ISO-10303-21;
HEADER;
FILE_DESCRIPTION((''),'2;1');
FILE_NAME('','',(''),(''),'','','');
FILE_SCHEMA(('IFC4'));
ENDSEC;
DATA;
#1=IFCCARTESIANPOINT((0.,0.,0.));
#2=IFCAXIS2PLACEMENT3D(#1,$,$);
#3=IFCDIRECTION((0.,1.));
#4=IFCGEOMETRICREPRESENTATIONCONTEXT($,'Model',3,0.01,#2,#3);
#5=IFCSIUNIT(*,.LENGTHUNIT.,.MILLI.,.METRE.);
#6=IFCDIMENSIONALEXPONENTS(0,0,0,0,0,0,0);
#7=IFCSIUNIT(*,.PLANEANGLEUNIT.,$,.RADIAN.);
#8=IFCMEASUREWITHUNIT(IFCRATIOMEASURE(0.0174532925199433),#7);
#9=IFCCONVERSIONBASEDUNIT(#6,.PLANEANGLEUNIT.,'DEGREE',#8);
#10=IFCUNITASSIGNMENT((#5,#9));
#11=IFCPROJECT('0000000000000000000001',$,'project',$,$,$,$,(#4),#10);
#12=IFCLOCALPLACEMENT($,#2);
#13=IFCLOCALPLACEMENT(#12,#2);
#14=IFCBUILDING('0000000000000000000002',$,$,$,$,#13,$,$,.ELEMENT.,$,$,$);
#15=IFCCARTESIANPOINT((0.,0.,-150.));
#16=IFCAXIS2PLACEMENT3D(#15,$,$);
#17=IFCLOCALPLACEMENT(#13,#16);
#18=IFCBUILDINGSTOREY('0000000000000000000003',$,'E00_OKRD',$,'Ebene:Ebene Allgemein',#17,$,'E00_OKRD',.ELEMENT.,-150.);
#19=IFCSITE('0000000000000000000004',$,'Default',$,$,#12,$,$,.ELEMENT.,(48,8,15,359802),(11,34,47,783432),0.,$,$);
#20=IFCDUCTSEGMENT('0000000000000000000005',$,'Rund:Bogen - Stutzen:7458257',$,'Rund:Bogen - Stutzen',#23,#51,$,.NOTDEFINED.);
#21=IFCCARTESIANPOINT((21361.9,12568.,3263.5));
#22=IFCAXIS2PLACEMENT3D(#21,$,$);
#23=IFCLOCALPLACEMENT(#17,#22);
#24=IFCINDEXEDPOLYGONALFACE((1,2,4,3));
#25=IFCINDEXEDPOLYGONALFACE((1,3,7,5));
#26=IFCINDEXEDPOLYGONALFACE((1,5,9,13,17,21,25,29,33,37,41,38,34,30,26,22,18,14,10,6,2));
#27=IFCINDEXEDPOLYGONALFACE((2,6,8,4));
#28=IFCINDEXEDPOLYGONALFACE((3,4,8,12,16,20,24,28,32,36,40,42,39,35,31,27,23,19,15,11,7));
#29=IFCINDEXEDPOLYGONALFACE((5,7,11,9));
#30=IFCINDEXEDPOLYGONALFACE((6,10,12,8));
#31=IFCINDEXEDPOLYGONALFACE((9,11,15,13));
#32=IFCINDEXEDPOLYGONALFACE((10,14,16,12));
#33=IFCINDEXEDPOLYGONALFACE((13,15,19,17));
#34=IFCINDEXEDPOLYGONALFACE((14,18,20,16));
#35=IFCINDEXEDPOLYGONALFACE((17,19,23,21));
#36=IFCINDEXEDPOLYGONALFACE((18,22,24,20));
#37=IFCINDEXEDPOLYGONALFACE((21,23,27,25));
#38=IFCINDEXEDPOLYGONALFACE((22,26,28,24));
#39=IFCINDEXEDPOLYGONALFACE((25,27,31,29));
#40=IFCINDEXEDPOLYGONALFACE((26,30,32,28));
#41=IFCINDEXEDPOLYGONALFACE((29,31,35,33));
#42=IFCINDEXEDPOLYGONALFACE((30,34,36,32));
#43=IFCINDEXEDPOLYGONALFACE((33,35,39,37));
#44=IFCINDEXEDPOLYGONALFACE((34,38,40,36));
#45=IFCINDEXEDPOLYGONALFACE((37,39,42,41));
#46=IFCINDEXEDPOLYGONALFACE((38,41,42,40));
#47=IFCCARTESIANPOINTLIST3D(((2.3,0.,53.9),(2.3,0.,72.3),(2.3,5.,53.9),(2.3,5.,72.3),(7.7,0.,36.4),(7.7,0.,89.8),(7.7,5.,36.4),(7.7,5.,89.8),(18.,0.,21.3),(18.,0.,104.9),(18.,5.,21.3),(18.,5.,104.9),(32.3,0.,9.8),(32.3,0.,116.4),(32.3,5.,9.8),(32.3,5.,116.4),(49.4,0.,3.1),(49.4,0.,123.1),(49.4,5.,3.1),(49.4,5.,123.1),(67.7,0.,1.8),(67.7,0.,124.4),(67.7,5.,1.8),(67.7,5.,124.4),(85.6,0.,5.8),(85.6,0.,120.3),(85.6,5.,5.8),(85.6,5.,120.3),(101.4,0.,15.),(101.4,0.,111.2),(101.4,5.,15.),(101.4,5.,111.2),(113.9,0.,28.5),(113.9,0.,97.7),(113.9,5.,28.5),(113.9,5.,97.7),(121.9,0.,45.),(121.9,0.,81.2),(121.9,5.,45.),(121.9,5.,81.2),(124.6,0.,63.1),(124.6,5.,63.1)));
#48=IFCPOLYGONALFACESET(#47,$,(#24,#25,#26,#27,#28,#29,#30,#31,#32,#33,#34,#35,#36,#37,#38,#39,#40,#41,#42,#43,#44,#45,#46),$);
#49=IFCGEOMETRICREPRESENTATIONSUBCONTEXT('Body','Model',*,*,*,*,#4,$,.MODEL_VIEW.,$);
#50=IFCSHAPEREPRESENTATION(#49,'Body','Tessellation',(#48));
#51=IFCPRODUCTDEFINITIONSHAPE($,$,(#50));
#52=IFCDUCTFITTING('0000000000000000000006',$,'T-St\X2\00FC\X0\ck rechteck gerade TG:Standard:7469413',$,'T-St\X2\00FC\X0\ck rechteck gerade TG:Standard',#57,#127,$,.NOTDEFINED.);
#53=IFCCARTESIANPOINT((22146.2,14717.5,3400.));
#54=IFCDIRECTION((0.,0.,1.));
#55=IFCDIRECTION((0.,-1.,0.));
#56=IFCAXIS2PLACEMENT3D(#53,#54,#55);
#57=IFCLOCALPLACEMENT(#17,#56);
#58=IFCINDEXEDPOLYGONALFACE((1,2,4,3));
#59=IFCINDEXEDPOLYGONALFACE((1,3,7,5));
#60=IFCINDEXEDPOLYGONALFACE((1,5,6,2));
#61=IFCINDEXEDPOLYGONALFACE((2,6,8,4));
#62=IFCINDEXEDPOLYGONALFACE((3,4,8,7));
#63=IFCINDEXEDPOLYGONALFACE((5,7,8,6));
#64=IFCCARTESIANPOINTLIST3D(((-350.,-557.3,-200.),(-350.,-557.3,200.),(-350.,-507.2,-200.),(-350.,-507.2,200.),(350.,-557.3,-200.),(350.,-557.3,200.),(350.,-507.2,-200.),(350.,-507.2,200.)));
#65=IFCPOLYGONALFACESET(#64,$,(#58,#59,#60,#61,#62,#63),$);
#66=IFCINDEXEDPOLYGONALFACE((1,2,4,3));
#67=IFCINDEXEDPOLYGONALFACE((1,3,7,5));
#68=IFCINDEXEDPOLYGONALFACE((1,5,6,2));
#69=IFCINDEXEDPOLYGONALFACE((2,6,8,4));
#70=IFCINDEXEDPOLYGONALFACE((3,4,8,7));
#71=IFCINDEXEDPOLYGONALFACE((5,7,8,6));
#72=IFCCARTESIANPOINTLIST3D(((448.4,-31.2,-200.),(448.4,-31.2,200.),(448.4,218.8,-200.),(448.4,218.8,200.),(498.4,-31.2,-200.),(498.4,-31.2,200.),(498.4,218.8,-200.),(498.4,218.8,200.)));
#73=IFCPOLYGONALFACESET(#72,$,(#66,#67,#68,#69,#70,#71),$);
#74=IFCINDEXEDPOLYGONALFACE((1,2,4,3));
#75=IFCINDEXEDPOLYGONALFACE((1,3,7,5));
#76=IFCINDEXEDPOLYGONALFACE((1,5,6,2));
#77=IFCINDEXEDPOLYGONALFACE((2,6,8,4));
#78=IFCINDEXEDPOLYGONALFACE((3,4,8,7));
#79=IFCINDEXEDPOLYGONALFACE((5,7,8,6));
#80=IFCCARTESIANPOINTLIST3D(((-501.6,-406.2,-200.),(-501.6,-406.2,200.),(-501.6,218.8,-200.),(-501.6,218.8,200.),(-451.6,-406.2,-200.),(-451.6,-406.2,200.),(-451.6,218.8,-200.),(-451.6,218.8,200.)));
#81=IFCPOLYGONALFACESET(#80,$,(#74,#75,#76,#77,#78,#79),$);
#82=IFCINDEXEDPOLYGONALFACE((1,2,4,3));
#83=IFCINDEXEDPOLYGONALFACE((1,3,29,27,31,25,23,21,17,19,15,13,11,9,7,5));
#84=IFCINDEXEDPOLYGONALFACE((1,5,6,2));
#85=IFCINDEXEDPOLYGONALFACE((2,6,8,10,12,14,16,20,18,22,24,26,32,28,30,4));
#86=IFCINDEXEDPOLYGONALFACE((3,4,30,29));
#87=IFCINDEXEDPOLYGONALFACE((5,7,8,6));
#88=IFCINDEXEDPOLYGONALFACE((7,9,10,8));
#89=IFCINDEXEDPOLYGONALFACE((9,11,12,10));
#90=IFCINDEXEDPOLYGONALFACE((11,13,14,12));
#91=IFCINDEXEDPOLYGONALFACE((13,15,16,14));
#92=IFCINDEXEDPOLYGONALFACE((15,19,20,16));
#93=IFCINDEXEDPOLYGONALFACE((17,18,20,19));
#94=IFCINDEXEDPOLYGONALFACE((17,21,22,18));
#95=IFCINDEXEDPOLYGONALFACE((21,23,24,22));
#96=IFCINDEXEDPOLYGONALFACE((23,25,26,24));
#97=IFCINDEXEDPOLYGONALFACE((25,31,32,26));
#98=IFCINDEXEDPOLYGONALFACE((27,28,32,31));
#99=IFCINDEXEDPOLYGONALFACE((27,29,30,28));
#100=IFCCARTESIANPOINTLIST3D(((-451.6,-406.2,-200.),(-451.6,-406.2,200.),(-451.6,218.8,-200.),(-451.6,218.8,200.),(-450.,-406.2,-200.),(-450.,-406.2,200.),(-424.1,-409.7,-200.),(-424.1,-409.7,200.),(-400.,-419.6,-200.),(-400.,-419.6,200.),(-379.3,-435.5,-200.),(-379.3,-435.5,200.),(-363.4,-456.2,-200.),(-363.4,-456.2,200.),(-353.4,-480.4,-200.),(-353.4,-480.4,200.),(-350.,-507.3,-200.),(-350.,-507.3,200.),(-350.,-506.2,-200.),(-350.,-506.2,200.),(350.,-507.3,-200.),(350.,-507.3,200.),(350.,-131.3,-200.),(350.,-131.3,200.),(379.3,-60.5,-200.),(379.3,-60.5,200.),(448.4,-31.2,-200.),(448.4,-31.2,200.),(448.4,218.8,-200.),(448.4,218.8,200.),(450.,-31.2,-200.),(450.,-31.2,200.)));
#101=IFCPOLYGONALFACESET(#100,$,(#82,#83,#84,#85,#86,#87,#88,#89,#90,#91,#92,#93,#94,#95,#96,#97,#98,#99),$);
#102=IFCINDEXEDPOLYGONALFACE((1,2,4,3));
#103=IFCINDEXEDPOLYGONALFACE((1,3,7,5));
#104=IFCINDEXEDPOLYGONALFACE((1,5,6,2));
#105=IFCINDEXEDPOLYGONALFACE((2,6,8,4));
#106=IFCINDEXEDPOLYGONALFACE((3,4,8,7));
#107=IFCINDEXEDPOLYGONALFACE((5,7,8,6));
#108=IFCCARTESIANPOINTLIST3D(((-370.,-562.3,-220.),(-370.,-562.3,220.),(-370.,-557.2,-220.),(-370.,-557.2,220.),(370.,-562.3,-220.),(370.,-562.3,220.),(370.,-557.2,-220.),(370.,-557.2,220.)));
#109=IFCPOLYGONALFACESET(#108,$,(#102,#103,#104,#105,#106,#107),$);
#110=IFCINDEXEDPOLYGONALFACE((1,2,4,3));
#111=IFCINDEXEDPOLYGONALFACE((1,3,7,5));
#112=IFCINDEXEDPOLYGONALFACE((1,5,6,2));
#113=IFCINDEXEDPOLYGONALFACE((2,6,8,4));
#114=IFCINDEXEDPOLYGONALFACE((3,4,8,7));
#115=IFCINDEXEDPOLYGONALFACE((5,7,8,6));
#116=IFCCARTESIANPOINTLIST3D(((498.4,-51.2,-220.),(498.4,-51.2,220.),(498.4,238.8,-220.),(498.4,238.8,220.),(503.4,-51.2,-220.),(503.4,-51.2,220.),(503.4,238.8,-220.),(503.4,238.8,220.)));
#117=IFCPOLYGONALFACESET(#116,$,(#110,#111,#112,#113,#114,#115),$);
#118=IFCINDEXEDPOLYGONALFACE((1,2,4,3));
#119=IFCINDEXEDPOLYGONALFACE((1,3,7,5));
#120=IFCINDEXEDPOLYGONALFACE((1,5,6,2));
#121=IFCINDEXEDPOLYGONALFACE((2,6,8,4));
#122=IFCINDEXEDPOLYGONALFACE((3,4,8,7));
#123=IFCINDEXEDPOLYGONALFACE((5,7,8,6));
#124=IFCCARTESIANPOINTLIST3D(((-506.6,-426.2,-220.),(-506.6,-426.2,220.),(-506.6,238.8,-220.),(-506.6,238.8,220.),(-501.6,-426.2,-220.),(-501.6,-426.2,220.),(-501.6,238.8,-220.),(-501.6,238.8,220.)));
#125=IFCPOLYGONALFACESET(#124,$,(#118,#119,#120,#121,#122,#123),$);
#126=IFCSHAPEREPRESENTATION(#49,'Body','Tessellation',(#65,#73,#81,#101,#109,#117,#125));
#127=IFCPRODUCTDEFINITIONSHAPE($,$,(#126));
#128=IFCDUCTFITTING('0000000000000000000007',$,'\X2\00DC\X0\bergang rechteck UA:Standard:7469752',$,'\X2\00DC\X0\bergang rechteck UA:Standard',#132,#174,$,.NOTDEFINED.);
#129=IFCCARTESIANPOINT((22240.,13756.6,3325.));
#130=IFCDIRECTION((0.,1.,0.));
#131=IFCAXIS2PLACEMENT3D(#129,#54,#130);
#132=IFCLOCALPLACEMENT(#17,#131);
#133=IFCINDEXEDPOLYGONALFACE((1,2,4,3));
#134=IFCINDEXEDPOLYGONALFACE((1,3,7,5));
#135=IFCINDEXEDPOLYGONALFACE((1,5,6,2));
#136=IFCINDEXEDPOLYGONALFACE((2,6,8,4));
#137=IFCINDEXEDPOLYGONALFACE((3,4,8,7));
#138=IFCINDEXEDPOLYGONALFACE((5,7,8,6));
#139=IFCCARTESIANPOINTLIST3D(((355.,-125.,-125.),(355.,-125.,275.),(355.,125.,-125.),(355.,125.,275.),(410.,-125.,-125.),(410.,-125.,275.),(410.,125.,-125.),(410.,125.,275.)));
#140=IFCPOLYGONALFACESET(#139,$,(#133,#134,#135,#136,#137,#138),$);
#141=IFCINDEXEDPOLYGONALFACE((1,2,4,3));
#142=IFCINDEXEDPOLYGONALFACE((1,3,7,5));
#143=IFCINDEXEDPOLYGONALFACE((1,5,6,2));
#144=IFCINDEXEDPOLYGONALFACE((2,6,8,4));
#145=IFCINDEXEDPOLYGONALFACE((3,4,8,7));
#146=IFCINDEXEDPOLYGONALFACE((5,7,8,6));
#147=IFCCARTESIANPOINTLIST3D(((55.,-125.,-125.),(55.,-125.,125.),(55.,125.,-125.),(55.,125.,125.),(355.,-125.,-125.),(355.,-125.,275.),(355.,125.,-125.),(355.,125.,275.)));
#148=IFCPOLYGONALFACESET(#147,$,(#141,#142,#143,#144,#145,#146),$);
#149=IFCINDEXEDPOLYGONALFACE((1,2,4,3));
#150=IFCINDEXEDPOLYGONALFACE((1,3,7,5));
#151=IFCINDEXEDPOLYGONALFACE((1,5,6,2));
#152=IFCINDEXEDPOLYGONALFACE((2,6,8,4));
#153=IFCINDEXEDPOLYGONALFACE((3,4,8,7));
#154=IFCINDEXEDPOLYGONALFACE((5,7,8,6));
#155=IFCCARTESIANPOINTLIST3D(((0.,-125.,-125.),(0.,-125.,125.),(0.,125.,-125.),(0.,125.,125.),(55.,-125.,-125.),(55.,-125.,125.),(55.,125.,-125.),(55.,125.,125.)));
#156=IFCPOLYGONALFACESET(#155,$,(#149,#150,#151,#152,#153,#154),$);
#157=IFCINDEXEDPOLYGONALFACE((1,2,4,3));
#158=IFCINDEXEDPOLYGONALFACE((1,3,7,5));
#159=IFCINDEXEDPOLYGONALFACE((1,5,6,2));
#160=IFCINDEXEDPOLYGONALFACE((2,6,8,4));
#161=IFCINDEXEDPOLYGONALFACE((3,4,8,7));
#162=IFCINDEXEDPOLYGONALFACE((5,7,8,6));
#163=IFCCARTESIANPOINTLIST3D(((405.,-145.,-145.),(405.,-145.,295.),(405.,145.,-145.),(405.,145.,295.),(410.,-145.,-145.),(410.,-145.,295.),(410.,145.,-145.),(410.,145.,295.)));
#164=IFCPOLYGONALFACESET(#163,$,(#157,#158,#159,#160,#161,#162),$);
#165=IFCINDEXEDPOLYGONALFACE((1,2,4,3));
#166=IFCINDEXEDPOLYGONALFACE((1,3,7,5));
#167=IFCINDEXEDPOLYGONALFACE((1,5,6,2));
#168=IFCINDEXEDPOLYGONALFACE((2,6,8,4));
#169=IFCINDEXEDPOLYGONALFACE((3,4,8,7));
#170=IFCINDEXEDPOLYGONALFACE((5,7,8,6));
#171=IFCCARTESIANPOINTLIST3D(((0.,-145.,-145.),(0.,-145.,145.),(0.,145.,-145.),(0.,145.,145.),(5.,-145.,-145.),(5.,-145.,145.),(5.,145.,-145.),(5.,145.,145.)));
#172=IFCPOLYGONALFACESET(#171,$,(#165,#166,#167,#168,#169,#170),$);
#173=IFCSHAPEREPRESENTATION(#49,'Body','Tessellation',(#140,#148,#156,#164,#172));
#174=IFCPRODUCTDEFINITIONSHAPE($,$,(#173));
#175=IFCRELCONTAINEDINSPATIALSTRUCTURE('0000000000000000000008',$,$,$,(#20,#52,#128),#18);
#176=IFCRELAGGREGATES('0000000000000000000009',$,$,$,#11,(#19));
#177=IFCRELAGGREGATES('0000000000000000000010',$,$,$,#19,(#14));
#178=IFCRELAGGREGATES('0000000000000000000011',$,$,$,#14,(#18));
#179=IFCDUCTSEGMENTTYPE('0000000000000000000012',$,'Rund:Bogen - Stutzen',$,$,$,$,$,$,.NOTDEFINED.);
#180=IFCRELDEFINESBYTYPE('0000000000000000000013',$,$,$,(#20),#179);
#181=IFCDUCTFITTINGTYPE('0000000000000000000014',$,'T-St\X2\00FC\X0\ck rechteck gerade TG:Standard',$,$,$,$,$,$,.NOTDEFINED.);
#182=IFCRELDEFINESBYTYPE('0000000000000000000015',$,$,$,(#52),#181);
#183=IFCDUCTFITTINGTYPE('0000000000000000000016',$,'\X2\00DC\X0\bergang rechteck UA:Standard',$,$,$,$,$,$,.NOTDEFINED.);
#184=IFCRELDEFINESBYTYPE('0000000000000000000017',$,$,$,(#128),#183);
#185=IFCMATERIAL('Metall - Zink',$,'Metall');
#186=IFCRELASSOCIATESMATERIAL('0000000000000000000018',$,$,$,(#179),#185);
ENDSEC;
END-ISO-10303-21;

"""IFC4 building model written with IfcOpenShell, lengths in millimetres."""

from ifc_helpers import new_model, entity, si_unit, converted_unit, direction, frame, frame_2d, origin, origin_2d_with_axis, place, context, subcontext, project, spatial, polyline, circle_curve, parameter, trimmed, segment, composite_curve, rectangle, circle, outline, extrude, source, transform, mapped, material, type_object, type_shapes, element, save


model = new_model("IFC4")

# Units and contexts
model_context = context("Model", 3, precision=0.01, world=origin(), true_north=direction((0.0, 1.0)))
body_context = subcontext(model_context, "Body", "Model", "MODEL_VIEW")
ifc_project = project(units=[si_unit("LENGTHUNIT", "METRE", prefix="MILLI"), converted_unit("PLANEANGLEUNIT", "DEGREE", entity("IfcRatioMeasure", 0.0174532925199433), si_unit("PLANEANGLEUNIT", "RADIAN"), dimensions=[0, 0, 0, 0, 0, 0, 0])], contexts=[model_context])

# Site, building, storey
site_placement = place(None, origin())
site = spatial("IfcSite", under=ifc_project, at=site_placement, Name="Default", CompositionType="ELEMENT", RefLatitude=(48, 8, 15, 359802), RefLongitude=(11, 34, 47, 783432), RefElevation=0.0)
building_placement = place(site_placement, origin())
building = spatial("IfcBuilding", under=site, at=building_placement, CompositionType="ELEMENT")
storey_placement = place(building_placement, frame((0.0, 0.0, -150.0)))
storey = spatial("IfcBuildingStorey", under=building, at=storey_placement, Name="E00_OKRD", ObjectType="Ebene:Ebene Allgemein", LongName="E00_OKRD", CompositionType="ELEMENT", Elevation=-150.0)

# Duct segment
ifc_material = material(Name="Metall - Zink", Category="Metall")
duct_segment_type_1 = type_object("IfcDuctSegmentType", Name="Rund:Bogen - Stutzen", PredefinedType="NOTDEFINED", material=ifc_material)
duct_segment_1_placement = place(storey_placement, frame((21361.9, 12568.0, 3263.5)))
element("IfcDuctSegment", 1, at=duct_segment_1_placement, inside=storey, type_object=duct_segment_type_1, Name="Rund:Bogen - Stutzen:7458257", ObjectType="Rund:Bogen - Stutzen", PredefinedType="NOTDEFINED", context=body_context, shape_type="SweptSolid", body=[
    extrude(circle(Radius=61.5, at=origin_2d_with_axis()), frame((63.1, 0.0, 63.1), z_axis=(0.0, 1.0, 0.0), x_axis=(1.0, 0.0, 0.0)), (0.0, 0.0, 1.0), 5.0),
])

# Duct fittings
duct_fitting_type_1 = type_object("IfcDuctFittingType", Name="T-Stück rechteck gerade TG:Standard", PredefinedType="NOTDEFINED")
shared_shape_1 = source(origin(), body_context, "Body", "SweptSolid", [
    extrude(rectangle(XDim=50.0, YDim=700.0, at=frame_2d((0.0, 0.0), x_axis=(1.0, 0.0))), frame((0.0, -532.2, -200.0), z_axis=(0.0, 0.0, 1.0), x_axis=(0.0, -1.0, 0.0)), (0.0, 0.0, 1.0), 400.0),
    extrude(rectangle(XDim=50.0, YDim=250.0, at=frame_2d((0.0, 0.0), x_axis=(1.0, 0.0))), frame((473.4, 93.8, -200.0), z_axis=(0.0, 0.0, 1.0), x_axis=(-1.0, 0.0, 0.0)), (0.0, 0.0, 1.0), 400.0),
    extrude(rectangle(XDim=50.0, YDim=625.0, at=origin_2d_with_axis()), frame((-476.6, -93.7, -200.0)), (0.0, 0.0, 1.0), 400.0),
    extrude(outline(composite_curve([segment(trimmed(circle_curve(frame_2d((-450.6, 77.7), x_axis=(-1.0, 0.0)), 100.0), [parameter(180.0)], [parameter(270.0)], True, "PARAMETER"), False, "CONTINUOUS"), segment(polyline([(-350.6, 77.7), (-350.6, -298.3)]), True, "CONTINUOUS"), segment(polyline([(-350.6, -298.3), (349.4, -298.3)]), True, "CONTINUOUS"), segment(polyline([(349.4, -298.3), (349.4, -297.3)]), True, "CONTINUOUS"), segment(trimmed(circle_curve(frame_2d((449.4, -297.3), x_axis=(-1.0, 0.0)), 100.0), [parameter(270.0)], [parameter(0.0)], True, "PARAMETER"), False, "CONTINUOUS"), segment(polyline([(449.4, -197.3), (451.0, -197.3)]), True, "CONTINUOUS"), segment(polyline([(451.0, -197.3), (451.0, 427.7)]), True, "CONTINUOUS"), segment(polyline([(451.0, 427.7), (-449.0, 427.7)]), True, "CONTINUOUS"), segment(polyline([(-449.0, 427.7), (-449.0, 177.7)]), True, "CONTINUOUS"), segment(polyline([(-449.0, 177.7), (-450.6, 177.7)]), True, "CONTINUOUS")], self_intersect=False)), frame((-0.6, -208.9, -200.0), z_axis=(0.0, 0.0, -1.0), x_axis=(-1.0, 0.0, 0.0)), (0.0, 0.0, -1.0), 400.0),
    extrude(rectangle(XDim=5.0, YDim=740.0, at=origin_2d_with_axis()), frame((0.0, -559.8, -220.0), z_axis=(0.0, 0.0, 1.0), x_axis=(0.0, 1.0, 0.0)), (0.0, 0.0, 1.0), 440.0),
    extrude(rectangle(XDim=5.0, YDim=290.0, at=origin_2d_with_axis()), frame((500.9, 93.8, -220.0), z_axis=(0.0, 0.0, 1.0), x_axis=(-1.0, 0.0, 0.0)), (0.0, 0.0, 1.0), 440.0),
    extrude(rectangle(XDim=5.0, YDim=665.0, at=frame_2d((0.0, 0.0), x_axis=(1.0, 0.0))), frame((-504.1, -93.7, -220.0), z_axis=(0.0, 0.0, 1.0), x_axis=(-1.0, 0.0, 0.0)), (0.0, 0.0, 1.0), 440.0),
])
type_shapes(duct_fitting_type_1, [shared_shape_1])
duct_fitting_1_placement = place(storey_placement, frame((22146.2, 14717.5, 3400.0), z_axis=(0.0, 0.0, 1.0), x_axis=(0.0, -1.0, 0.0)))
element("IfcDuctFitting", 2, at=duct_fitting_1_placement, inside=storey, type_object=duct_fitting_type_1, Name="T-Stück rechteck gerade TG:Standard:7469413", ObjectType="T-Stück rechteck gerade TG:Standard", PredefinedType="NOTDEFINED", context=body_context, shape_type="MappedRepresentation", body=[
    mapped(shared_shape_1, transform((0.0, 0.0, 0.0), scale=1.0)),
])
duct_fitting_type_2 = type_object("IfcDuctFittingType", Name="Übergang rechteck UA:Standard", PredefinedType="NOTDEFINED")
shared_shape_2 = source(origin(), body_context, "Body", "SweptSolid", [
    extrude(rectangle(XDim=55.0, YDim=250.0, at=frame_2d((0.0, 0.0), x_axis=(1.0, 0.0))), frame((382.5, 0.0, -125.0)), (0.0, 0.0, 1.0), 400.0),
    extrude(outline(polyline([(-95.0, -145.3), (240.4, -145.3), (61.5, 212.4), (-206.8, 78.3), (-95.0, -145.3)])), frame((205.0, -125.0, 37.5), z_axis=(0.0, 1.0, 0.0), x_axis=(0.894427, 0.0, 0.447214)), (0.0, 0.0, 1.0), 250.0),
    extrude(rectangle(XDim=55.0, YDim=250.0, at=frame_2d((0.0, 0.0), x_axis=(1.0, 0.0))), frame((27.5, 0.0, -125.0)), (0.0, 0.0, 1.0), 250.0),
    extrude(rectangle(XDim=5.0, YDim=290.0, at=frame_2d((0.0, 0.0), x_axis=(1.0, 0.0))), frame((407.5, 0.0, -145.0)), (0.0, 0.0, 1.0), 440.0),
    extrude(rectangle(XDim=5.0, YDim=290.0, at=frame_2d((0.0, 0.0), x_axis=(1.0, 0.0))), frame((2.5, 0.0, -145.0)), (0.0, 0.0, 1.0), 290.0),
])
type_shapes(duct_fitting_type_2, [shared_shape_2])
duct_fitting_2_placement = place(storey_placement, frame((22240.0, 13756.6, 3325.0), z_axis=(0.0, 0.0, 1.0), x_axis=(0.0, 1.0, 0.0)))
element("IfcDuctFitting", 3, at=duct_fitting_2_placement, inside=storey, type_object=duct_fitting_type_2, Name="Übergang rechteck UA:Standard:7469752", ObjectType="Übergang rechteck UA:Standard", PredefinedType="NOTDEFINED", context=body_context, shape_type="MappedRepresentation", body=[
    mapped(shared_shape_2, transform((0.0, 0.0, 0.0), scale=1.0)),
])

save(model, "model.ifc")
